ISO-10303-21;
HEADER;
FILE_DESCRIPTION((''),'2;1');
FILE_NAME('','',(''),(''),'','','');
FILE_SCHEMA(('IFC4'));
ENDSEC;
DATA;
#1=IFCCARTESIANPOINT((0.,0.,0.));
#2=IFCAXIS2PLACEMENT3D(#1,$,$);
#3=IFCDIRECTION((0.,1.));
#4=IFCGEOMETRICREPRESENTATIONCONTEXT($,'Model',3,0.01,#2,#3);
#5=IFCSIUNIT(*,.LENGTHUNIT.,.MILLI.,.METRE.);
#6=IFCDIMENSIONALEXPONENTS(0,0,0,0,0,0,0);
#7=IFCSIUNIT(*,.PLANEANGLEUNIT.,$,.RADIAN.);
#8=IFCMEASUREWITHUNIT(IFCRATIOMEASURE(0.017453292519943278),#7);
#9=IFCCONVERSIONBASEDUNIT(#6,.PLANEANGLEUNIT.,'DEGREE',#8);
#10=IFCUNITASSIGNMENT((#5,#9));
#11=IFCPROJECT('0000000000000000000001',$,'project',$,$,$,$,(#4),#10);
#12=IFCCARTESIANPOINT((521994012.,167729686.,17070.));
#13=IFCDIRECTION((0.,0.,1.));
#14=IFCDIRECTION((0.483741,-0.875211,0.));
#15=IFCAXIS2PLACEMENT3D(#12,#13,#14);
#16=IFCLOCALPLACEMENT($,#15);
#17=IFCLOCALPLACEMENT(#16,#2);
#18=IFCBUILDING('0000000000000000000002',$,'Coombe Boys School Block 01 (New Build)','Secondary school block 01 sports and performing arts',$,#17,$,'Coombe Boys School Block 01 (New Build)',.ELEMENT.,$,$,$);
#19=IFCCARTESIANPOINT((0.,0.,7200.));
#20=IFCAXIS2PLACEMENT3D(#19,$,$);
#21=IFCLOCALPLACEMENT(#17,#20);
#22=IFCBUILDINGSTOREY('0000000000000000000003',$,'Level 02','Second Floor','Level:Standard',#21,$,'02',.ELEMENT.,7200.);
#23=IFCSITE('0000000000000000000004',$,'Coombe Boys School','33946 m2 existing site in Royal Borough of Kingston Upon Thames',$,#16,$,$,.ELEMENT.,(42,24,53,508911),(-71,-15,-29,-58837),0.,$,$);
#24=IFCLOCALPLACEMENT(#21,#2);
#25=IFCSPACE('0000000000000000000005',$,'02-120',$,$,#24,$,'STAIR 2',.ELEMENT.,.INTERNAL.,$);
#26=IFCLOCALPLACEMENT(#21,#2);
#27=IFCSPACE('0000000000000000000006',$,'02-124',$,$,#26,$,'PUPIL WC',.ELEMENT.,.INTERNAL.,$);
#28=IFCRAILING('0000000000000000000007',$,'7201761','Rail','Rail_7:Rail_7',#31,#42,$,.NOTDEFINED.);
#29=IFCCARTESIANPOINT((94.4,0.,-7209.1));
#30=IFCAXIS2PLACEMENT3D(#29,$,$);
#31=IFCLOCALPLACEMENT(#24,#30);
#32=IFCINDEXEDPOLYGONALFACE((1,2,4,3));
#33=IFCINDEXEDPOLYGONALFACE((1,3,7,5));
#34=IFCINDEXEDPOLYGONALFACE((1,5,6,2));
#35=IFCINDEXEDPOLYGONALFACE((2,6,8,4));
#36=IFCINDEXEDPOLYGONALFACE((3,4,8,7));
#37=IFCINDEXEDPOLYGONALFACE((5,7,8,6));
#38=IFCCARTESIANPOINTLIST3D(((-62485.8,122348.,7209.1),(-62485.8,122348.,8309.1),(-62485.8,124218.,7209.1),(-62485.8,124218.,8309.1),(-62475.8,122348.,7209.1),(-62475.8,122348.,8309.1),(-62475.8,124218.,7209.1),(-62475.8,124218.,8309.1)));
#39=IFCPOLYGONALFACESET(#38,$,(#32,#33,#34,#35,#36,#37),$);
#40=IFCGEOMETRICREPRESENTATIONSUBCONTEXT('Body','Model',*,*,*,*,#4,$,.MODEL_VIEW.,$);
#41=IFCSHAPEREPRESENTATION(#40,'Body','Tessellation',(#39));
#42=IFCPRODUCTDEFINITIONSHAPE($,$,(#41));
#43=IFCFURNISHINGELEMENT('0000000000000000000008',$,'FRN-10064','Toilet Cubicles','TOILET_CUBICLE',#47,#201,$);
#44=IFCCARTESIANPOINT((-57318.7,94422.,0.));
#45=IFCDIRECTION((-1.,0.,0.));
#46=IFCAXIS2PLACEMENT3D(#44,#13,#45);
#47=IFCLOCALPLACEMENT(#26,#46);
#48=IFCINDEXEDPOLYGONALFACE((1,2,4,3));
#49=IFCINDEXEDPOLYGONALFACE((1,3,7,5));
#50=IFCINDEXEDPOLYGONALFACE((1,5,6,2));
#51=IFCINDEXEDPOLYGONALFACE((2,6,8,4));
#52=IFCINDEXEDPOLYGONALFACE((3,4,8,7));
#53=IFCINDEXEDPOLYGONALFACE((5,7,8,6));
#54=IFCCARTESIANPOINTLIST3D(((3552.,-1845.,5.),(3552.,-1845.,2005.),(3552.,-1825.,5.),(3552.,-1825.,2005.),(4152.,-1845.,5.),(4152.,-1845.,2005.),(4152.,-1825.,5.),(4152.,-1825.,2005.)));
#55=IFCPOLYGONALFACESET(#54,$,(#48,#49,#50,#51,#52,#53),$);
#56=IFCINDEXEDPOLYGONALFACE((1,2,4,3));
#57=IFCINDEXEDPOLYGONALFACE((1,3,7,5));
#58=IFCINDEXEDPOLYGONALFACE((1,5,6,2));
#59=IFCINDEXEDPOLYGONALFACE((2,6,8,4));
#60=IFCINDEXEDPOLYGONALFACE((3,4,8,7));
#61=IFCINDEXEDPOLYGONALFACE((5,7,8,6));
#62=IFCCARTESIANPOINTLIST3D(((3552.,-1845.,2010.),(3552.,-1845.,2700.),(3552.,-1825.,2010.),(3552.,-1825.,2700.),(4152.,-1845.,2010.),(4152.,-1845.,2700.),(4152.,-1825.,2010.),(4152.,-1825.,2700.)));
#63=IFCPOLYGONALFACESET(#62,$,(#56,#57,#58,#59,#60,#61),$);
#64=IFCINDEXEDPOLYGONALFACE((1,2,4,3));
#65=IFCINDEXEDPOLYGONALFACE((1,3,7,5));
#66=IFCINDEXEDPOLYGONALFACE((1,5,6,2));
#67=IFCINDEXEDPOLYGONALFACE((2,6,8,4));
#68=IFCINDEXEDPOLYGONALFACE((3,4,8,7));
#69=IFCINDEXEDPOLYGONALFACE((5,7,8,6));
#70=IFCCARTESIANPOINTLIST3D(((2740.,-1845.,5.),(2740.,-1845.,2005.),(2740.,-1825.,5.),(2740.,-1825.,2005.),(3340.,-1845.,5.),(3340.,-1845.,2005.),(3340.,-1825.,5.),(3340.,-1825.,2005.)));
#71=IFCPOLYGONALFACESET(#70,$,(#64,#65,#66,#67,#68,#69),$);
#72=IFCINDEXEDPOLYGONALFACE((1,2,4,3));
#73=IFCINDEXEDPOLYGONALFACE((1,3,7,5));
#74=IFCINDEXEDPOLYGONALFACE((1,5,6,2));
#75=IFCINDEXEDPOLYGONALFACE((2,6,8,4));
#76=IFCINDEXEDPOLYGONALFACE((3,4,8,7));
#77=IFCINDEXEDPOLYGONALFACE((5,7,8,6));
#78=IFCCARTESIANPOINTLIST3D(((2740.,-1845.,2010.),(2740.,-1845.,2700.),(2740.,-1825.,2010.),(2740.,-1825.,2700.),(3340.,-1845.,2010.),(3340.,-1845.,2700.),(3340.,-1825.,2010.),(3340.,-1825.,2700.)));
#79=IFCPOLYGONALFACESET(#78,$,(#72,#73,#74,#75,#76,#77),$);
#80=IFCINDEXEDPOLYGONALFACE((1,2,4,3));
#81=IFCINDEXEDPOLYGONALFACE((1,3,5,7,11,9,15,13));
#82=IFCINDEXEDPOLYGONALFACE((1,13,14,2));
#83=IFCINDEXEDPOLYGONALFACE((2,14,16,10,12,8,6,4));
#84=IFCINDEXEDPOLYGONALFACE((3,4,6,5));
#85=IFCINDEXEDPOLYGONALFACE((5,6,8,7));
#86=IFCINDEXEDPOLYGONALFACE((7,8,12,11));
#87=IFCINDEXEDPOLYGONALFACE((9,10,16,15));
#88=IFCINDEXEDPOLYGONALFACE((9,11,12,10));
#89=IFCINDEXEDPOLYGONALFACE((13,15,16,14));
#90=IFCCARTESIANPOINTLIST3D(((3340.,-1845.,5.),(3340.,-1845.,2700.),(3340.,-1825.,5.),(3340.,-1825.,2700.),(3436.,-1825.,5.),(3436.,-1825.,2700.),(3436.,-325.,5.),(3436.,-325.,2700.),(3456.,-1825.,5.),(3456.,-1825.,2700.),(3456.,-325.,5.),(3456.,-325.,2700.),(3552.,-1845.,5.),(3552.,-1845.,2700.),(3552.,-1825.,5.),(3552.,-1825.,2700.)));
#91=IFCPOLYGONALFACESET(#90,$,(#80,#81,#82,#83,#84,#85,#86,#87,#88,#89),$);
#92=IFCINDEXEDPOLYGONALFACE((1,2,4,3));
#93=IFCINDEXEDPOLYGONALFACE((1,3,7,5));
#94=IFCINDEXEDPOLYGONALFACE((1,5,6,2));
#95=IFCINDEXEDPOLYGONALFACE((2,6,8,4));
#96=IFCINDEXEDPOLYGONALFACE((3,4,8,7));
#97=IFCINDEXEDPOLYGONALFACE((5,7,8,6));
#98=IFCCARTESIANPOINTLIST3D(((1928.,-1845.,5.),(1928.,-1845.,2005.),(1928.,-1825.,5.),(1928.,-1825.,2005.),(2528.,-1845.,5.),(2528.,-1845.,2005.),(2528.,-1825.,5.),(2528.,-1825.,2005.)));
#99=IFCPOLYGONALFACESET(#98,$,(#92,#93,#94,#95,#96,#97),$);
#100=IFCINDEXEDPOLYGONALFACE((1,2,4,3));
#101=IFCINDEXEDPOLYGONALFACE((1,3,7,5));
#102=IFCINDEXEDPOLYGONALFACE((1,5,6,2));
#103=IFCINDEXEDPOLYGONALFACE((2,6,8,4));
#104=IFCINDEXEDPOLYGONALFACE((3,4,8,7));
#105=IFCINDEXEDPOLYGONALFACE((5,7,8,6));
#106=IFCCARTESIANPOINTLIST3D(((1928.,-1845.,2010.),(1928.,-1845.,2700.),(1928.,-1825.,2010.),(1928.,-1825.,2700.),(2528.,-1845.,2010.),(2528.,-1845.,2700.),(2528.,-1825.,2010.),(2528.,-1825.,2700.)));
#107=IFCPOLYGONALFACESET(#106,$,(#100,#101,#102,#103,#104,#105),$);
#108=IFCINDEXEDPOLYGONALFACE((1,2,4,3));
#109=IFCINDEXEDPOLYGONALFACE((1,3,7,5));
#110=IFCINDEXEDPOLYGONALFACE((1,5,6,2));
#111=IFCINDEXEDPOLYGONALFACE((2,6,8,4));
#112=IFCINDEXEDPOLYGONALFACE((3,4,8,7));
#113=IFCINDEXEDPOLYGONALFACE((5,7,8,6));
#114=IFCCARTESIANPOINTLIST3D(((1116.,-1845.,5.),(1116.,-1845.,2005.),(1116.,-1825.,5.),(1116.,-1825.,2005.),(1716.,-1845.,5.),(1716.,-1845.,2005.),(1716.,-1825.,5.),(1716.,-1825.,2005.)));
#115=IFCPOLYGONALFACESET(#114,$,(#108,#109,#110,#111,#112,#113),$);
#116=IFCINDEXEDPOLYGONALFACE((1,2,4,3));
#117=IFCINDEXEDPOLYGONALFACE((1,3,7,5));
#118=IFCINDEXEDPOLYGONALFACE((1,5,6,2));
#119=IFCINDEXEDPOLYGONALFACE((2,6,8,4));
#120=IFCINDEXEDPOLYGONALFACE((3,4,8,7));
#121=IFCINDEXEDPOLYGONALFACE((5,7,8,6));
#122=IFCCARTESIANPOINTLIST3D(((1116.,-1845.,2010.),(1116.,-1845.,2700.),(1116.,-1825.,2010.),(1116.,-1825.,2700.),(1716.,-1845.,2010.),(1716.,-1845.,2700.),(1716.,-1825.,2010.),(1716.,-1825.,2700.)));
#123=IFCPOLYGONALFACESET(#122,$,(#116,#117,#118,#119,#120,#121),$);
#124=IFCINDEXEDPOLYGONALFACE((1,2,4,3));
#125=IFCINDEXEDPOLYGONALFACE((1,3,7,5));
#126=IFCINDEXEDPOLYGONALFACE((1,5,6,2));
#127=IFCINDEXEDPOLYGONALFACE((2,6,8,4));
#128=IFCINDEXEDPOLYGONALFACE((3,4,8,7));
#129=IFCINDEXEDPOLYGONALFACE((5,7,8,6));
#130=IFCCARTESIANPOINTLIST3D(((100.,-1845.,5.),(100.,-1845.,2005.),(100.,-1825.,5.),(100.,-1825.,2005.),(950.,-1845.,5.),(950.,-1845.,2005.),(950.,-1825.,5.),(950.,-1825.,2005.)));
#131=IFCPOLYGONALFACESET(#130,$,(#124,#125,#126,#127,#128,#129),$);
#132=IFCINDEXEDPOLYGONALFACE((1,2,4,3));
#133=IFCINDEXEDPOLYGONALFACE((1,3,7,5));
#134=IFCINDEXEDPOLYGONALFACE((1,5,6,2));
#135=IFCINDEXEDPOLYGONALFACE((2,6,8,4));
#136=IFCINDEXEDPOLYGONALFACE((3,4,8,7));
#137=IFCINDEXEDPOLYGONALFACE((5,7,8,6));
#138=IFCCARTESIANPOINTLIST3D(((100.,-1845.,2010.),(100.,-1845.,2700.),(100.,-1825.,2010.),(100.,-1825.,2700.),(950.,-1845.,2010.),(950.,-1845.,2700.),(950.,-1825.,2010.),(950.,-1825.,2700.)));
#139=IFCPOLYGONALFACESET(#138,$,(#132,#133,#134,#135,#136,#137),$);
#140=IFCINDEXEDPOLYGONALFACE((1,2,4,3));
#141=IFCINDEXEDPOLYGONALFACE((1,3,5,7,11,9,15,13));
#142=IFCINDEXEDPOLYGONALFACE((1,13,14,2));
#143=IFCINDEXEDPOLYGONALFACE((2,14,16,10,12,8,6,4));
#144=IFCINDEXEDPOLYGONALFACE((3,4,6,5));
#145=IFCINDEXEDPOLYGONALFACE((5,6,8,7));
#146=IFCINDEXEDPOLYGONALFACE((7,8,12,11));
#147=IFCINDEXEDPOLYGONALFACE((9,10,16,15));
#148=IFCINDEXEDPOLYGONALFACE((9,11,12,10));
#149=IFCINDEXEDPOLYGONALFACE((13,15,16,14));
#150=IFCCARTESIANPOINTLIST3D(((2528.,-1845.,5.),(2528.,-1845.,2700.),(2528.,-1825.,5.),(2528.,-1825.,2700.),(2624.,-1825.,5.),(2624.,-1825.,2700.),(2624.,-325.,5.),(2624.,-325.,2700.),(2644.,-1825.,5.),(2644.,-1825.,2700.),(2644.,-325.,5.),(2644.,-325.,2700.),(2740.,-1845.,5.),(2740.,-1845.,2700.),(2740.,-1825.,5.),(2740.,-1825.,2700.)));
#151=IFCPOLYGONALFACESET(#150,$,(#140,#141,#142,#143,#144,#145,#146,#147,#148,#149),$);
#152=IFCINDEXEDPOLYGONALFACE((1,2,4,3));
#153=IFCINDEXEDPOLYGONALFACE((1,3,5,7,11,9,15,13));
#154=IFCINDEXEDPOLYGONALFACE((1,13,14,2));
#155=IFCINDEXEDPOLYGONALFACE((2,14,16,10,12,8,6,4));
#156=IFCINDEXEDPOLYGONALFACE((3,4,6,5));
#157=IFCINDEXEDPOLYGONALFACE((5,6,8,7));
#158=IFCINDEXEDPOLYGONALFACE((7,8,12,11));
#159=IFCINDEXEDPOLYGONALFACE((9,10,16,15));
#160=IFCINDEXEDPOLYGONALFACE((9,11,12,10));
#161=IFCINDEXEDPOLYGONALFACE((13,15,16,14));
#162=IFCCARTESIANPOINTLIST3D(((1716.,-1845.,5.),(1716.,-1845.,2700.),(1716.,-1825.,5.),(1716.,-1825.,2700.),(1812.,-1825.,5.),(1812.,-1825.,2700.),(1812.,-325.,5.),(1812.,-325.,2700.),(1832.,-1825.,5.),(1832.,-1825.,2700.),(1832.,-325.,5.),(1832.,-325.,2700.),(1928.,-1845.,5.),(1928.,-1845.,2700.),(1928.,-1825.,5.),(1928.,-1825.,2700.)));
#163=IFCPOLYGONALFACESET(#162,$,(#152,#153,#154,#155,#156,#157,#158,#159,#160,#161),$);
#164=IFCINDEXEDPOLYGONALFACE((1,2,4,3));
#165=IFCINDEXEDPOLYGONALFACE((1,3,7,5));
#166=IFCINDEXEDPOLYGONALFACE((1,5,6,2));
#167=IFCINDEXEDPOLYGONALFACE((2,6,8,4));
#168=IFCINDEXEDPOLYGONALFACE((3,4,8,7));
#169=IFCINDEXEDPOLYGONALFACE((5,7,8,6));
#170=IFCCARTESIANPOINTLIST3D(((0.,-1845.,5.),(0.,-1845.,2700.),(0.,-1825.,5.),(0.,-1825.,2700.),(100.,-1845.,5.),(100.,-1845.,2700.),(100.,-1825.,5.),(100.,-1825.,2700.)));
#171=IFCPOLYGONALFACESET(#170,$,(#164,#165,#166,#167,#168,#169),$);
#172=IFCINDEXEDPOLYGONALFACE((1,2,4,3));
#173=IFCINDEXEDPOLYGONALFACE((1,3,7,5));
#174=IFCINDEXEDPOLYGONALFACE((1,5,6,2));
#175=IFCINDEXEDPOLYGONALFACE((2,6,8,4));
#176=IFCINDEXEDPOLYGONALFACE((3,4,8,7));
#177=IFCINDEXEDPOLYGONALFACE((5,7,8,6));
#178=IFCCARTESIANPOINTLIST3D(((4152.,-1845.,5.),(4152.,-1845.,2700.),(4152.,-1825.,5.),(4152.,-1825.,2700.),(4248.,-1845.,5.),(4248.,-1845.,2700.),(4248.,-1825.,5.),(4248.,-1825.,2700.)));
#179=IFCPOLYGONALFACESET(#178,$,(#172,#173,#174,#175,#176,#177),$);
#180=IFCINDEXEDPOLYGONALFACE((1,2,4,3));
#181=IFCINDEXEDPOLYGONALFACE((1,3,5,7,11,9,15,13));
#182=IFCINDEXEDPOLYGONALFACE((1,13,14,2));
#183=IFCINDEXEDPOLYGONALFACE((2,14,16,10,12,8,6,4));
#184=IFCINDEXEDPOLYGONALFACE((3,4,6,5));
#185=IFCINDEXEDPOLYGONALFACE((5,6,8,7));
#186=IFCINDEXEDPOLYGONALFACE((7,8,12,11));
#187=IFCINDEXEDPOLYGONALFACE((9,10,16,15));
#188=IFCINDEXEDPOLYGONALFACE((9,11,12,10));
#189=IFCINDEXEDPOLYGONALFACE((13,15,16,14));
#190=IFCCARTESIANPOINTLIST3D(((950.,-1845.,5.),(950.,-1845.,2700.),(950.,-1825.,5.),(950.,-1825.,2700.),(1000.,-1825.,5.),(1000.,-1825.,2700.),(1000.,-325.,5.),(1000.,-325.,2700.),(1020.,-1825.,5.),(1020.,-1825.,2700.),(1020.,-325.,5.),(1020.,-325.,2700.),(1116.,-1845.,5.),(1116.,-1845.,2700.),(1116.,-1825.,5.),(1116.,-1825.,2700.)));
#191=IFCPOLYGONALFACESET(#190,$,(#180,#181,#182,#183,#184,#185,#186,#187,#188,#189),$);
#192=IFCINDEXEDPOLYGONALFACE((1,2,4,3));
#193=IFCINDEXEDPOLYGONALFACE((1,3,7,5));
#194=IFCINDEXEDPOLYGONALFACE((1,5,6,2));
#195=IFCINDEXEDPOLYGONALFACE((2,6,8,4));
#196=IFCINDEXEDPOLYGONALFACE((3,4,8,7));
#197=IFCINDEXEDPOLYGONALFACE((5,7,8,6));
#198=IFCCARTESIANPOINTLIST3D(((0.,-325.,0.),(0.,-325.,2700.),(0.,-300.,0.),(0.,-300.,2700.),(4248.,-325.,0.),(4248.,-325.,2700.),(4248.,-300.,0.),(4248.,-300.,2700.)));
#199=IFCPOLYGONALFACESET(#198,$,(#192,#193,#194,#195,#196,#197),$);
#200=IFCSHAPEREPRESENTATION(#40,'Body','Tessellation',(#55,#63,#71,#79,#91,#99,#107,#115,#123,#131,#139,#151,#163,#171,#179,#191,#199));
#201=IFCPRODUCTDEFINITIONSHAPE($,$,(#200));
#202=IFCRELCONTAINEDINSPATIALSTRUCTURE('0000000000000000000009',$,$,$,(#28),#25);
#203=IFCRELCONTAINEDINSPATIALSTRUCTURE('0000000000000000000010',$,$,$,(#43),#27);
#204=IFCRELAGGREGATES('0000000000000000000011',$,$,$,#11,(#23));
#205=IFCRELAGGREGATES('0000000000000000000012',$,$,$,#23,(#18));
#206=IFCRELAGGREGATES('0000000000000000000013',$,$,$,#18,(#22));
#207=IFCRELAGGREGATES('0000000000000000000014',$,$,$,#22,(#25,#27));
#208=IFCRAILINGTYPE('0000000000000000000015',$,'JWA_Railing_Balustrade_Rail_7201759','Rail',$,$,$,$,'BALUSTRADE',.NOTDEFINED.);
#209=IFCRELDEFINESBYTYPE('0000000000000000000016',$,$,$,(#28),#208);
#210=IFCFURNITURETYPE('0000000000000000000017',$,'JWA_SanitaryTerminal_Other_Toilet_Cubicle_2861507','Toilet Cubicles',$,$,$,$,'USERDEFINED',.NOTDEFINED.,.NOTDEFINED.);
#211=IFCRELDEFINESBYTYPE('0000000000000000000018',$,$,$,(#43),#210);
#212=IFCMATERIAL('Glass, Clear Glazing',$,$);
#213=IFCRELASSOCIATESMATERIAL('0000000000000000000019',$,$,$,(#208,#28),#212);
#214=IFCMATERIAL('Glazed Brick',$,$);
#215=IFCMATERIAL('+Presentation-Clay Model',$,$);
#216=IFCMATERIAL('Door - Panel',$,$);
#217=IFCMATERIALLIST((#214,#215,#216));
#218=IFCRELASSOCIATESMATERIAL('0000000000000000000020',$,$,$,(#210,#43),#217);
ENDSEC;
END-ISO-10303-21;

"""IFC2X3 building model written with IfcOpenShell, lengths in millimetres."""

from ifc_helpers import new_model, entity, si_unit, converted_unit, direction, frame, frame_2d, origin, origin_2d_with_axis, place, context, subcontext, project, spatial, polyline, rectangle, outline, extrude, source, transform, mapped, material, material_list, type_object, type_shapes, element, save


model = new_model("IFC2X3")

# Units and contexts
model_context = context("Model", 3, precision=0.01, world=origin(), true_north=direction((0.0, 1.0)))
body_context = subcontext(model_context, "Body", "Model", "MODEL_VIEW")
ifc_project = project(units=[si_unit("LENGTHUNIT", "METRE", prefix="MILLI"), converted_unit("PLANEANGLEUNIT", "DEGREE", entity("IfcRatioMeasure", 0.017453292519943278), si_unit("PLANEANGLEUNIT", "RADIAN"), dimensions=[0, 0, 0, 0, 0, 0, 0])], contexts=[model_context])

# Site, building, storey
site_placement = place(None, frame((521994012.0, 167729686.0, 17070.0), z_axis=(0.0, 0.0, 1.0), x_axis=(0.483741, -0.875211, 0.0)))
site = spatial("IfcSite", under=ifc_project, at=site_placement, Name="Coombe Boys School", Description="33946 m2 existing site in Royal Borough of Kingston Upon Thames", CompositionType="ELEMENT", RefLatitude=(42, 24, 53, 508911), RefLongitude=(-71, -15, -29, -58837), RefElevation=0.0)
building_placement = place(site_placement, origin())
building = spatial("IfcBuilding", under=site, at=building_placement, Name="Coombe Boys School Block 01 (New Build)", Description="Secondary school block 01 sports and performing arts", LongName="Coombe Boys School Block 01 (New Build)", CompositionType="ELEMENT")
storey_placement = place(building_placement, frame((0.0, 0.0, 7200.0)))
storey = spatial("IfcBuildingStorey", under=building, at=storey_placement, Name="Level 02", Description="Second Floor", ObjectType="Level:Standard", LongName="02", CompositionType="ELEMENT", Elevation=7200.0)

# Shared definitions
ifc_material_1 = material(Name="+Presentation-Clay Model")

# Shared definitions
space_1_placement = place(storey_placement, origin())
space_1 = spatial("IfcSpace", under=storey, at=space_1_placement, Name="02-120", LongName="STAIR 2", CompositionType="ELEMENT", InteriorOrExteriorSpace="INTERNAL")

# Railing
ifc_material_2 = material(Name="Glass, Clear Glazing")
railing_type = type_object("IfcRailingType", Name="JWA_Railing_Balustrade_Rail_7201759", Description="Rail", ElementType="BALUSTRADE", PredefinedType="NOTDEFINED", material=ifc_material_2)
shared_shape_1 = source(origin(), body_context, "Body", "SweptSolid", [
    extrude(rectangle(XDim=10.0, YDim=1870.0, at=frame_2d((0.0, 0.0), x_axis=(1.0, 0.0))), frame((-62480.8, 123283.0, 7209.1)), (0.0, 0.0, 1.0), 1100.0),
])
type_shapes(railing_type, [shared_shape_1])
railing_1_placement = place(space_1_placement, frame((94.4, 0.0, -7209.1)))
element("IfcRailing", 1, at=railing_1_placement, inside=space_1, type_object=railing_type, material=ifc_material_2, Name="7201761", Description="Rail", ObjectType="Rail_7:Rail_7", PredefinedType="NOTDEFINED", context=body_context, shape_type="MappedRepresentation", body=[
    mapped(shared_shape_1, transform((0.0, 0.0, 0.0), scale=1.0)),
])

# Shared definitions
space_2_placement = place(storey_placement, origin())
space_2 = spatial("IfcSpace", under=storey, at=space_2_placement, Name="02-124", LongName="PUPIL WC", CompositionType="ELEMENT", InteriorOrExteriorSpace="INTERNAL")

# Furnishing element
ifc_material_3 = material(Name="Glazed Brick")
ifc_material_4 = material(Name="Door - Panel")
ifc_material_list = material_list([ifc_material_3, ifc_material_1, ifc_material_4])
furniture_type_1 = type_object("IfcFurnitureType", Name="JWA_SanitaryTerminal_Other_Toilet_Cubicle_2861507", Description="Toilet Cubicles", ElementType="USERDEFINED", material=ifc_material_list)
shared_shape_2 = source(origin(), body_context, "Body", "SweptSolid", [
    extrude(rectangle(XDim=20.0, YDim=600.0, at=frame_2d((0.0, 0.0), x_axis=(1.0, 0.0))), frame((3852.0, -1835.0, 5.0), z_axis=(0.0, 0.0, 1.0), x_axis=(0.0, 1.0, 0.0)), (0.0, 0.0, 1.0), 2000.0),
    extrude(rectangle(XDim=20.0, YDim=600.0, at=frame_2d((0.0, 0.0), x_axis=(1.0, 0.0))), frame((3852.0, -1835.0, 2010.0), z_axis=(0.0, 0.0, 1.0), x_axis=(0.0, 1.0, 0.0)), (0.0, 0.0, 1.0), 690.0),
    extrude(rectangle(XDim=20.0, YDim=600.0, at=frame_2d((0.0, 0.0), x_axis=(1.0, 0.0))), frame((3040.0, -1835.0, 5.0), z_axis=(0.0, 0.0, 1.0), x_axis=(0.0, 1.0, 0.0)), (0.0, 0.0, 1.0), 2000.0),
    extrude(rectangle(XDim=20.0, YDim=600.0, at=frame_2d((0.0, 0.0), x_axis=(1.0, 0.0))), frame((3040.0, -1835.0, 2010.0), z_axis=(0.0, 0.0, 1.0), x_axis=(0.0, 1.0, 0.0)), (0.0, 0.0, 1.0), 690.0),
    extrude(outline(polyline([(-370.0, -10.0), (1130.0, -10.0), (1130.0, 10.0), (-370.0, 10.0), (-370.0, 106.0), (-390.0, 106.0), (-390.0, -106.0), (-370.0, -106.0), (-370.0, -10.0)])), frame((3446.0, -1455.0, 5.0), z_axis=(0.0, 0.0, 1.0), x_axis=(0.0, 1.0, 0.0)), (0.0, 0.0, 1.0), 2695.0),
    extrude(rectangle(XDim=20.0, YDim=600.0, at=frame_2d((0.0, 0.0), x_axis=(1.0, 0.0))), frame((2228.0, -1835.0, 5.0), z_axis=(0.0, 0.0, 1.0), x_axis=(0.0, 1.0, 0.0)), (0.0, 0.0, 1.0), 2000.0),
    extrude(rectangle(XDim=20.0, YDim=600.0, at=frame_2d((0.0, 0.0), x_axis=(1.0, 0.0))), frame((2228.0, -1835.0, 2010.0), z_axis=(0.0, 0.0, 1.0), x_axis=(0.0, 1.0, 0.0)), (0.0, 0.0, 1.0), 690.0),
    extrude(rectangle(XDim=20.0, YDim=600.0, at=frame_2d((0.0, 0.0), x_axis=(1.0, 0.0))), frame((1416.0, -1835.0, 5.0), z_axis=(0.0, 0.0, 1.0), x_axis=(0.0, 1.0, 0.0)), (0.0, 0.0, 1.0), 2000.0),
    extrude(rectangle(XDim=20.0, YDim=600.0, at=frame_2d((0.0, 0.0), x_axis=(1.0, 0.0))), frame((1416.0, -1835.0, 2010.0), z_axis=(0.0, 0.0, 1.0), x_axis=(0.0, 1.0, 0.0)), (0.0, 0.0, 1.0), 690.0),
    extrude(rectangle(XDim=20.0, YDim=850.0, at=frame_2d((0.0, 0.0), x_axis=(1.0, 0.0))), frame((525.0, -1835.0, 5.0), z_axis=(0.0, 0.0, 1.0), x_axis=(0.0, -1.0, 0.0)), (0.0, 0.0, 1.0), 2000.0),
    extrude(rectangle(XDim=20.0, YDim=850.0, at=frame_2d((0.0, 0.0), x_axis=(1.0, 0.0))), frame((525.0, -1835.0, 2010.0), z_axis=(0.0, 0.0, 1.0), x_axis=(0.0, -1.0, 0.0)), (0.0, 0.0, 1.0), 690.0),
    extrude(outline(polyline([(-370.0, -10.0), (1130.0, -10.0), (1130.0, 10.0), (-370.0, 10.0), (-370.0, 106.0), (-390.0, 106.0), (-390.0, -106.0), (-370.0, -106.0), (-370.0, -10.0)])), frame((2634.0, -1455.0, 5.0), z_axis=(0.0, 0.0, 1.0), x_axis=(0.0, 1.0, 0.0)), (0.0, 0.0, 1.0), 2695.0),
    extrude(outline(polyline([(-370.0, -10.0), (1130.0, -10.0), (1130.0, 10.0), (-370.0, 10.0), (-370.0, 106.0), (-390.0, 106.0), (-390.0, -106.0), (-370.0, -106.0), (-370.0, -10.0)])), frame((1822.0, -1455.0, 5.0), z_axis=(0.0, 0.0, 1.0), x_axis=(0.0, 1.0, 0.0)), (0.0, 0.0, 1.0), 2695.0),
    extrude(rectangle(XDim=20.0, YDim=100.0, at=frame_2d((0.0, 0.0), x_axis=(1.0, 0.0))), frame((50.0, -1835.0, 5.0), z_axis=(0.0, 0.0, 1.0), x_axis=(0.0, -1.0, 0.0)), (0.0, 0.0, 1.0), 2695.0),
    extrude(rectangle(XDim=96.0, YDim=20.0, at=origin_2d_with_axis()), frame((4200.0, -1835.0, 5.0), z_axis=(0.0, 0.0, 1.0), x_axis=(-1.0, 0.0, 0.0)), (0.0, 0.0, 1.0), 2695.0),
    extrude(outline(polyline([(-390.0, -94.5), (-370.0, -94.5), (-370.0, 1.5), (1130.0, 1.5), (1130.0, 21.5), (-370.0, 21.5), (-370.0, 71.5), (-390.0, 71.5), (-390.0, -94.5)])), frame((1021.5, -1455.0, 5.0), z_axis=(0.0, 0.0, 1.0), x_axis=(0.0, 1.0, 0.0)), (0.0, 0.0, 1.0), 2695.0),
    extrude(rectangle(XDim=25.0, YDim=4248.0, at=frame_2d((0.0, 0.0), x_axis=(1.0, 0.0))), frame((2124.0, -312.5, 0.0), z_axis=(0.0, 0.0, 1.0), x_axis=(0.0, 1.0, 0.0)), (0.0, 0.0, 1.0), 2700.0),
])
type_shapes(furniture_type_1, [shared_shape_2])
furnishing_1_placement = place(space_2_placement, frame((-57318.7, 94422.0, 0.0), z_axis=(0.0, 0.0, 1.0), x_axis=(-1.0, 0.0, 0.0)))
element("IfcFurnishingElement", 2, at=furnishing_1_placement, inside=space_2, type_object=furniture_type_1, material=ifc_material_list, Name="FRN-10064", Description="Toilet Cubicles", ObjectType="TOILET_CUBICLE", context=body_context, shape_type="MappedRepresentation", body=[
    mapped(shared_shape_2, transform((0.0, 0.0, 0.0), scale=1.0)),
])

save(model, "model.ifc")
